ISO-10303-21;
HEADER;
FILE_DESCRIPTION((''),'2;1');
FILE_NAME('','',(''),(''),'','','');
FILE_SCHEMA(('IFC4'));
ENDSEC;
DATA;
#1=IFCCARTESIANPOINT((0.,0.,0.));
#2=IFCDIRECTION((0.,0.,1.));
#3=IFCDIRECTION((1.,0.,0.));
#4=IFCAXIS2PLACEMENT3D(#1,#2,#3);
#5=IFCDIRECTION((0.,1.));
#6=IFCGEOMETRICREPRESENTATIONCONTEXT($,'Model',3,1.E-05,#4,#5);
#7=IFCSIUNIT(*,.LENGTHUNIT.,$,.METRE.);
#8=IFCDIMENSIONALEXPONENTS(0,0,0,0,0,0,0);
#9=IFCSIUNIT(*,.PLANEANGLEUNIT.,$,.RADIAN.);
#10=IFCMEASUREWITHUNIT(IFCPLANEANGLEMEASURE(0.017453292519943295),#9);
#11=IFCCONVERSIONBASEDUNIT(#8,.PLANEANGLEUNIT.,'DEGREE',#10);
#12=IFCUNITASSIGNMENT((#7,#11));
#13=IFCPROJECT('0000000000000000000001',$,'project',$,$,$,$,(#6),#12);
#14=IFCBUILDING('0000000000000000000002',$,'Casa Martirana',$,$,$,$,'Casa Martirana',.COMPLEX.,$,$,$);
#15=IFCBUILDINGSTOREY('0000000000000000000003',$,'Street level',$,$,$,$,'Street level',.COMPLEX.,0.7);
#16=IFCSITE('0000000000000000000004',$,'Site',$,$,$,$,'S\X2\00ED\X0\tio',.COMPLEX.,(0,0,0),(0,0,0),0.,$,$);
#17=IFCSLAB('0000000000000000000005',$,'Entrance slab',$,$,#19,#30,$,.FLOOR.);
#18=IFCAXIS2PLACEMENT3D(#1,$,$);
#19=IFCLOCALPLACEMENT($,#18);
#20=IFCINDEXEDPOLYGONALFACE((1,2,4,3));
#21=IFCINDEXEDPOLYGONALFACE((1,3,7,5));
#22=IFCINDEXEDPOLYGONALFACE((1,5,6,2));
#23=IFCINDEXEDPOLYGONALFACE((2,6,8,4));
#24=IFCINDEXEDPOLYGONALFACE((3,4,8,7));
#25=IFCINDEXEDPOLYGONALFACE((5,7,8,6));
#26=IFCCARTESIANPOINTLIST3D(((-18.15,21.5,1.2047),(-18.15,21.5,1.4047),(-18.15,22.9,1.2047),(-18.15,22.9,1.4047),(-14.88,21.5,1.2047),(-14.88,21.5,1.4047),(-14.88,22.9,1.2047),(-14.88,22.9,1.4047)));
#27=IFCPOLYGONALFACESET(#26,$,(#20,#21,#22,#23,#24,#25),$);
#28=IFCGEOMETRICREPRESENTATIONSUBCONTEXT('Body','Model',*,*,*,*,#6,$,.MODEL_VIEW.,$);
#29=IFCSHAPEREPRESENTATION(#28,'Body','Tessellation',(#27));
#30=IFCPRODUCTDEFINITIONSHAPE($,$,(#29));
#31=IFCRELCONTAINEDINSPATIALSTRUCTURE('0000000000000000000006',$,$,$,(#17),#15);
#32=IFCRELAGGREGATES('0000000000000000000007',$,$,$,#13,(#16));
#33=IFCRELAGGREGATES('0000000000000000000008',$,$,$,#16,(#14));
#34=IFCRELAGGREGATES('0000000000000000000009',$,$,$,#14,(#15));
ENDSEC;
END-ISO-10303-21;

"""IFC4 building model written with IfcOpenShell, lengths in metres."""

from ifc_helpers import new_model, entity, si_unit, converted_unit, direction, frame, origin_with_axes, origin_2d_with_axis, place, context, subcontext, project, spatial, rectangle, extrude, element, save


model = new_model("IFC4")

# Units and contexts
model_context = context("Model", 3, precision=1e-05, world=origin_with_axes(), true_north=direction((0.0, 1.0)))
body_context = subcontext(model_context, "Body", "Model", "MODEL_VIEW")
ifc_project = project(units=[si_unit("LENGTHUNIT", "METRE"), converted_unit("PLANEANGLEUNIT", "DEGREE", entity("IfcPlaneAngleMeasure", 0.017453292519943295), si_unit("PLANEANGLEUNIT", "RADIAN"), dimensions=[0, 0, 0, 0, 0, 0, 0])], contexts=[model_context])

# Site, building, storey
site = spatial("IfcSite", under=ifc_project, Name="Site", LongName="Sítio", CompositionType="COMPLEX", RefLatitude=(0, 0, 0), RefLongitude=(0, 0, 0), RefElevation=0.0)
building = spatial("IfcBuilding", under=site, Name="Casa Martirana", LongName="Casa Martirana", CompositionType="COMPLEX")
storey = spatial("IfcBuildingStorey", under=building, Name="Street level", LongName="Street level", CompositionType="COMPLEX", Elevation=0.7)

# Slab
slab_placement = place(None, origin_with_axes())
element("IfcSlab", 1, at=slab_placement, inside=storey, Name="Entrance slab", PredefinedType="FLOOR", context=body_context, shape_type="SweptSolid", body=[
    extrude(rectangle(XDim=3.27, YDim=1.4, at=origin_2d_with_axis()), frame((-16.515, 22.2, 1.4047), z_axis=(0.0, 0.0, 1.0), x_axis=(1.0, 0.0, 0.0)), (0.0, 0.0, -1.0), 0.2),
])

save(model, "model.ifc")
